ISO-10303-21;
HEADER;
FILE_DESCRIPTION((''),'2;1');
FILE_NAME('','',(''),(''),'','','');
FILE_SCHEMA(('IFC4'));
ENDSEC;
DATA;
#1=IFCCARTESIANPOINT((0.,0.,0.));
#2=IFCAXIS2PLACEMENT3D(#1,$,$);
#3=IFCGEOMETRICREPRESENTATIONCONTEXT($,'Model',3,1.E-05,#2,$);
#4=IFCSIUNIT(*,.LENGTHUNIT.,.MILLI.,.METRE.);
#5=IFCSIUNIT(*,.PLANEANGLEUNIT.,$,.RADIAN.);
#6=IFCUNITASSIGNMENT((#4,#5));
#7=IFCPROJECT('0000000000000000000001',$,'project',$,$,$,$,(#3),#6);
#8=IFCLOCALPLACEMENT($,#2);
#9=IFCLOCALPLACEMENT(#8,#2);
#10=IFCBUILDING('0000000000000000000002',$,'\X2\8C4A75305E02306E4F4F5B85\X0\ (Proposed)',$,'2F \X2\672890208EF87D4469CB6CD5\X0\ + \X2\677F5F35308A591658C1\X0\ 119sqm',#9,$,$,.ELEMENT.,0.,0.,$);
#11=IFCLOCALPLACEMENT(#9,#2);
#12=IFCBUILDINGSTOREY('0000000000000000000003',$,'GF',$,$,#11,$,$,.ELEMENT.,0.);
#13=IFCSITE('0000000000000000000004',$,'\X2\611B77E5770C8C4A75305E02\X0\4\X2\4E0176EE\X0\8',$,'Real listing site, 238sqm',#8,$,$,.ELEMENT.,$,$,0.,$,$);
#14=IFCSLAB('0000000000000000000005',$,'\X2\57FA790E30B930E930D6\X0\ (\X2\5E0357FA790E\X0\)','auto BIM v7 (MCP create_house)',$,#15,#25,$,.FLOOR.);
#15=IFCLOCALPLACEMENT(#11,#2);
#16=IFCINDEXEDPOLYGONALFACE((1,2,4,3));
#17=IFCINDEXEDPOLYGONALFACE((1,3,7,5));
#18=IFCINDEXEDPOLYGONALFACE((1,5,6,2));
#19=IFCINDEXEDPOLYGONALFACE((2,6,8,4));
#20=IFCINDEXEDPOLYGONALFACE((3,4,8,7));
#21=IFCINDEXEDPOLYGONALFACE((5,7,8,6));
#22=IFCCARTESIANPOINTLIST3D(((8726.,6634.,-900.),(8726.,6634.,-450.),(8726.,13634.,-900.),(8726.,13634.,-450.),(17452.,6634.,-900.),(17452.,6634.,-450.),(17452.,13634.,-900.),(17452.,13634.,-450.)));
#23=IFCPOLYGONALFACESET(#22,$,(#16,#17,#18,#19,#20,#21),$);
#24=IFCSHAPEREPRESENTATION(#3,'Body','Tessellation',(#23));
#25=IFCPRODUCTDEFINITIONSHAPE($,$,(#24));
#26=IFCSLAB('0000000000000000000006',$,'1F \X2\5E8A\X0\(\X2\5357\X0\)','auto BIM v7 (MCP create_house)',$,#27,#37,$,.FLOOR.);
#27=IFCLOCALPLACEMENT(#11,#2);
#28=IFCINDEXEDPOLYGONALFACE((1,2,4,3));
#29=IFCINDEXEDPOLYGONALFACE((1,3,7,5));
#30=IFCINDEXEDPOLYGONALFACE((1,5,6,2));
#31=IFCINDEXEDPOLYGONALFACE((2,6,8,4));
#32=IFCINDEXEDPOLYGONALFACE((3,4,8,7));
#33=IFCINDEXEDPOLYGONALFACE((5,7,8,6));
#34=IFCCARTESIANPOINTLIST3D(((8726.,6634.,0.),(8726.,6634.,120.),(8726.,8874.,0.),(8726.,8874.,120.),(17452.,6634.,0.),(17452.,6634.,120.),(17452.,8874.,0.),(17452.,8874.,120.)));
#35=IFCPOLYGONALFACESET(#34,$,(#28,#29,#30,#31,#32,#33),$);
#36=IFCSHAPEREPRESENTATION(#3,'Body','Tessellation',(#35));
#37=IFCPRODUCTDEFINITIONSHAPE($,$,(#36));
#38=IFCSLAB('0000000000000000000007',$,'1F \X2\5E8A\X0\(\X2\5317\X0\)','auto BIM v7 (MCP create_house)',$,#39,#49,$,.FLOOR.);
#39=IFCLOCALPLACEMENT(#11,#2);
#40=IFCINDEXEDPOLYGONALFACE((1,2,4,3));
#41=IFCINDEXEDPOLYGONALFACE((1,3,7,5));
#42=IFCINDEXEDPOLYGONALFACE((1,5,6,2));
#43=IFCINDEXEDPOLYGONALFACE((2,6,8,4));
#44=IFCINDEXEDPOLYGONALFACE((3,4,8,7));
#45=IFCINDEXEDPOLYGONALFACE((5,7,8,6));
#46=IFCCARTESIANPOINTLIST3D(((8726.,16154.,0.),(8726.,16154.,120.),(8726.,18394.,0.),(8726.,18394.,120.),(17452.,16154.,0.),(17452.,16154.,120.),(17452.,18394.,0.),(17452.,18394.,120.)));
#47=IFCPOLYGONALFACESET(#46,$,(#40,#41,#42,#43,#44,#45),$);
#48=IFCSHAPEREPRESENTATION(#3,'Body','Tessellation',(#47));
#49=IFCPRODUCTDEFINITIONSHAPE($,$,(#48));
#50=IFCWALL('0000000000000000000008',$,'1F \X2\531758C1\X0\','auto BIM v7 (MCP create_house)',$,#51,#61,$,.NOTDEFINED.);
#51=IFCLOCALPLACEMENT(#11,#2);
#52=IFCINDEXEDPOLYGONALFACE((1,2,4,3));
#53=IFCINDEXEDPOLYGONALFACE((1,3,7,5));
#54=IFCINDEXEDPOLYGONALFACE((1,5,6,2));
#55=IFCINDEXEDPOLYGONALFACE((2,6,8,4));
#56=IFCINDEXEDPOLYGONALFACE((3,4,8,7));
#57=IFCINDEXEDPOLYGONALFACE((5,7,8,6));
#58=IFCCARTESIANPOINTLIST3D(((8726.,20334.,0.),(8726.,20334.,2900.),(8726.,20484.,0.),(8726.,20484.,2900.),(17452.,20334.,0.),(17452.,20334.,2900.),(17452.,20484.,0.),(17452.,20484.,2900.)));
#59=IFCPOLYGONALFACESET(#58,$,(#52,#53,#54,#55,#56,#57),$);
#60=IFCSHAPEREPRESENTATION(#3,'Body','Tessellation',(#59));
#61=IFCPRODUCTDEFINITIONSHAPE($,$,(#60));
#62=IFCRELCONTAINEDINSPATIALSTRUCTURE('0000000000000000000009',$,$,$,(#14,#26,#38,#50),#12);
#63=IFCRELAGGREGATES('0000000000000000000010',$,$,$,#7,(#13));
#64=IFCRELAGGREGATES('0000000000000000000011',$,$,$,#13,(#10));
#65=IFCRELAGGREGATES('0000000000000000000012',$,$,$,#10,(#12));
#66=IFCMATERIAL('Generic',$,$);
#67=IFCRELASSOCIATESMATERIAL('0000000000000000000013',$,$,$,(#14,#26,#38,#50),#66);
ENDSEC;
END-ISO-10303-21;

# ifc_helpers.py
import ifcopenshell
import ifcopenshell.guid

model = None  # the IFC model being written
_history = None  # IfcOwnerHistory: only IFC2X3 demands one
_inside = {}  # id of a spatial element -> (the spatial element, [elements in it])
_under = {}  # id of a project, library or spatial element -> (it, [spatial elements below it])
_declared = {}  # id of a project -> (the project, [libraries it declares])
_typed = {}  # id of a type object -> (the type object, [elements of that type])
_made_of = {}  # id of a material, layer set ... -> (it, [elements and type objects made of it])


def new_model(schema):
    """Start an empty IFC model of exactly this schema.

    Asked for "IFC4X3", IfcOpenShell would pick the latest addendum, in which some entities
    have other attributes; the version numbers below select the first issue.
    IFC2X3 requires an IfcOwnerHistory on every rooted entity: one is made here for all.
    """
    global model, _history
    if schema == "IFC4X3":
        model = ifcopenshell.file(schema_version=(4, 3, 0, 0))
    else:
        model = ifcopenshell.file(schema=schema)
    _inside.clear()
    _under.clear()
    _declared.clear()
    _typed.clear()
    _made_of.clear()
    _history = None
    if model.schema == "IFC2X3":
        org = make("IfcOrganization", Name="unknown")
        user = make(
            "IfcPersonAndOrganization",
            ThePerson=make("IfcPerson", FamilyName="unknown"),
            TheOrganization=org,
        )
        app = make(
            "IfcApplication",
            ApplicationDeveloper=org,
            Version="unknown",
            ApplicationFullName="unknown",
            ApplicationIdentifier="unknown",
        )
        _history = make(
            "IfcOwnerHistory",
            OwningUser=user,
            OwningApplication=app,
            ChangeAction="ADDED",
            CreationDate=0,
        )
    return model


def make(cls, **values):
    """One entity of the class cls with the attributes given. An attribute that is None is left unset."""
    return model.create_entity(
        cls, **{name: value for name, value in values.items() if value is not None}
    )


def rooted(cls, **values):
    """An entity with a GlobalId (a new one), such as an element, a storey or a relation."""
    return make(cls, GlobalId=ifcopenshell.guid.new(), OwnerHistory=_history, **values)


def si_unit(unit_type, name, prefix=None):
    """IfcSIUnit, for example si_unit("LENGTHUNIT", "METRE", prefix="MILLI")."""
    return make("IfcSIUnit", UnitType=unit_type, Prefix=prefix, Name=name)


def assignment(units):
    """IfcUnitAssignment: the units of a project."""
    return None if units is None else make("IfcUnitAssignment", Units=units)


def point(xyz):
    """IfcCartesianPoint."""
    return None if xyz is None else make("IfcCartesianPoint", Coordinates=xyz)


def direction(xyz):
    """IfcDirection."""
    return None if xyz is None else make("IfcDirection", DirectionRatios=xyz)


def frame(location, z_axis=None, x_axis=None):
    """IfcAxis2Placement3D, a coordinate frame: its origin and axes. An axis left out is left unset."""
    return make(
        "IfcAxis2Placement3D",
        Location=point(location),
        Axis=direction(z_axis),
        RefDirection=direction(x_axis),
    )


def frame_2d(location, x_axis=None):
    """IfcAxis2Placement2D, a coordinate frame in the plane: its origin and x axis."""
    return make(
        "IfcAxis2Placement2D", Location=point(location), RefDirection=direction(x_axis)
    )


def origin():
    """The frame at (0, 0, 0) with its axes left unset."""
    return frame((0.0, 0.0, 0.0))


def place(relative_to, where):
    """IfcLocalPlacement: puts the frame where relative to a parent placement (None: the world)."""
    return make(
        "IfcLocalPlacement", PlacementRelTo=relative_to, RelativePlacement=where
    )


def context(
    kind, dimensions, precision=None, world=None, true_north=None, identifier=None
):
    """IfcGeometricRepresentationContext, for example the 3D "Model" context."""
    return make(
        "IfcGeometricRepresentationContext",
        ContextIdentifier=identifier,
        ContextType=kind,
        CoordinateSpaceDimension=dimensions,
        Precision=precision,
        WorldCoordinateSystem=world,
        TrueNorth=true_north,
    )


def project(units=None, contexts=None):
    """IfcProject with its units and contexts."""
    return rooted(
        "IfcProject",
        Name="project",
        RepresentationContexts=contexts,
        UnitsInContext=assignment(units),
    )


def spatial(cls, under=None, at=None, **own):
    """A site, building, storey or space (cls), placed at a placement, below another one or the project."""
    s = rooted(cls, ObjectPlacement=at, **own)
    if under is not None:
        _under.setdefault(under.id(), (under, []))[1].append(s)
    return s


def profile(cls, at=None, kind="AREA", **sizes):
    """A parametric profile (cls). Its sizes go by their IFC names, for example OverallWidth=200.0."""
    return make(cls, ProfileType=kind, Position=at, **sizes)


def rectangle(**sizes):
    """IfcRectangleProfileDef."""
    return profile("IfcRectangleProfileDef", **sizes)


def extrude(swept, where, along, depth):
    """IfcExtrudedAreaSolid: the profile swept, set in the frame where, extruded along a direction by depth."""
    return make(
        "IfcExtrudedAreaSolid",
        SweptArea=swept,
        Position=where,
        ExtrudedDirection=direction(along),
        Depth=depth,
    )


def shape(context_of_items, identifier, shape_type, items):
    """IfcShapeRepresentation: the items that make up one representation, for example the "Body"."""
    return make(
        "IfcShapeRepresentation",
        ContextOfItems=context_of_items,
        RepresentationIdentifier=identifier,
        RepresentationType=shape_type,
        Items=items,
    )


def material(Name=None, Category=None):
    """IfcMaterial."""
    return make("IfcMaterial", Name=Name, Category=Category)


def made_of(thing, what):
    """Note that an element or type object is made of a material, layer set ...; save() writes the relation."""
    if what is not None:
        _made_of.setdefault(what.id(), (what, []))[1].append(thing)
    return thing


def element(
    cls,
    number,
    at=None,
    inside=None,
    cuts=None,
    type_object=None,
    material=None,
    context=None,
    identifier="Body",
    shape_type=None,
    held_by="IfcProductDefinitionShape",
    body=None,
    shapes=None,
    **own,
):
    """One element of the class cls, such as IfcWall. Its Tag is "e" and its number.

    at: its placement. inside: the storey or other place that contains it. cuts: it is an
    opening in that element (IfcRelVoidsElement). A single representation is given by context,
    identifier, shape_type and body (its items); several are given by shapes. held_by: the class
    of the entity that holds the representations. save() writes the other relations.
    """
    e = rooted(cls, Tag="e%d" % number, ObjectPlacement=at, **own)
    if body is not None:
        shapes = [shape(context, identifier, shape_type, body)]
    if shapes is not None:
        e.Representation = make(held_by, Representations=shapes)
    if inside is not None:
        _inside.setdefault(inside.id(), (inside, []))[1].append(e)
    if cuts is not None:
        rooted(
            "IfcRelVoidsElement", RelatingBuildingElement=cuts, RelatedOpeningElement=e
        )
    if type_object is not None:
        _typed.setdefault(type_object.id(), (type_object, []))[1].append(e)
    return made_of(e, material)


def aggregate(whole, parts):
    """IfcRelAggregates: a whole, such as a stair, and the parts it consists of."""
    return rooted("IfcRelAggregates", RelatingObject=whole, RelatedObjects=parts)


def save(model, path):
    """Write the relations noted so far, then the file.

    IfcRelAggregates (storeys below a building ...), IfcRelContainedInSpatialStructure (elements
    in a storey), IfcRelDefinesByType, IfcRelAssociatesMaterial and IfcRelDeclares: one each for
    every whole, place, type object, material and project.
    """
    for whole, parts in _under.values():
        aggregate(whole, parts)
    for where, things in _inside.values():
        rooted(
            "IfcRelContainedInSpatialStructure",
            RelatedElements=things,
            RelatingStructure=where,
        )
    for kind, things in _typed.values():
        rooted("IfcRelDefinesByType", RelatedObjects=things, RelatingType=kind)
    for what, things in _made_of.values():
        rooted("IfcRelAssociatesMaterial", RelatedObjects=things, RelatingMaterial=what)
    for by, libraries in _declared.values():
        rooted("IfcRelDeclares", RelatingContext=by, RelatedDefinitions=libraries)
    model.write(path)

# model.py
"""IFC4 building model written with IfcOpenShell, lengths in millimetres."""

from ifc_helpers import new_model, si_unit, frame, frame_2d, origin, place, context, project, spatial, rectangle, extrude, material, element, save


model = new_model("IFC4")

# Units and contexts
model_context = context("Model", 3, precision=1e-05, world=origin())
ifc_project = project(units=[si_unit("LENGTHUNIT", "METRE", prefix="MILLI"), si_unit("PLANEANGLEUNIT", "RADIAN")], contexts=[model_context])

# Site, building, storey
site_placement = place(None, origin())
site = spatial("IfcSite", under=ifc_project, at=site_placement, Name="愛知県豊田市4丁目8", ObjectType="Real listing site, 238sqm", CompositionType="ELEMENT", RefElevation=0.0)
building_placement = place(site_placement, origin())
building = spatial("IfcBuilding", under=site, at=building_placement, Name="豊田市の住宅 (Proposed)", ObjectType="2F 木造軸組構法 + 板張り外壁 119sqm", CompositionType="ELEMENT", ElevationOfRefHeight=0.0, ElevationOfTerrain=0.0)
storey_placement = place(building_placement, origin())
storey = spatial("IfcBuildingStorey", under=building, at=storey_placement, Name="GF", CompositionType="ELEMENT", Elevation=0.0)

# Slabs
ifc_material = material(Name="Generic")
slab_1_placement = place(storey_placement, frame((4363.0, 3317.0, -450.0)))
element("IfcSlab", 1, at=slab_1_placement, inside=storey, material=ifc_material, Name="基礎スラブ (布基礎)", Description="auto BIM v7 (MCP create_house)", PredefinedType="FLOOR", context=model_context, shape_type="SweptSolid", body=[
    extrude(rectangle(XDim=8726.0, YDim=7000.0, at=frame_2d((4363.0, 3500.0))), frame((4363.0, 3317.0, -450.0)), (0.0, 0.0, 1.0), 450.0),
])
slab_2_placement = place(storey_placement, frame((4363.0, 3317.0, 0.0)))
element("IfcSlab", 2, at=slab_2_placement, inside=storey, material=ifc_material, Name="1F 床(南)", Description="auto BIM v7 (MCP create_house)", PredefinedType="FLOOR", context=model_context, shape_type="SweptSolid", body=[
    extrude(rectangle(XDim=8726.0, YDim=2240.0, at=frame_2d((4363.0, 1120.0))), frame((4363.0, 3317.0, 0.0)), (0.0, 0.0, 1.0), 120.0),
])
slab_3_placement = place(storey_placement, frame((4363.0, 8077.0, 0.0)))
element("IfcSlab", 3, at=slab_3_placement, inside=storey, material=ifc_material, Name="1F 床(北)", Description="auto BIM v7 (MCP create_house)", PredefinedType="FLOOR", context=model_context, shape_type="SweptSolid", body=[
    extrude(rectangle(XDim=8726.0, YDim=2240.0, at=frame_2d((4363.0, 1120.0))), frame((4363.0, 8077.0, 0.0)), (0.0, 0.0, 1.0), 120.0),
])

# Wall
wall_1_placement = place(storey_placement, frame((4363.0, 10167.0, 0.0)))
element("IfcWall", 4, at=wall_1_placement, inside=storey, material=ifc_material, Name="1F 北壁", Description="auto BIM v7 (MCP create_house)", PredefinedType="NOTDEFINED", context=model_context, shape_type="SweptSolid", body=[
    extrude(rectangle(XDim=8726.0, YDim=150.0, at=frame_2d((4363.0, 75.0))), frame((4363.0, 10167.0, 0.0)), (0.0, 0.0, 1.0), 2900.0),
])

save(model, "model.ifc")
